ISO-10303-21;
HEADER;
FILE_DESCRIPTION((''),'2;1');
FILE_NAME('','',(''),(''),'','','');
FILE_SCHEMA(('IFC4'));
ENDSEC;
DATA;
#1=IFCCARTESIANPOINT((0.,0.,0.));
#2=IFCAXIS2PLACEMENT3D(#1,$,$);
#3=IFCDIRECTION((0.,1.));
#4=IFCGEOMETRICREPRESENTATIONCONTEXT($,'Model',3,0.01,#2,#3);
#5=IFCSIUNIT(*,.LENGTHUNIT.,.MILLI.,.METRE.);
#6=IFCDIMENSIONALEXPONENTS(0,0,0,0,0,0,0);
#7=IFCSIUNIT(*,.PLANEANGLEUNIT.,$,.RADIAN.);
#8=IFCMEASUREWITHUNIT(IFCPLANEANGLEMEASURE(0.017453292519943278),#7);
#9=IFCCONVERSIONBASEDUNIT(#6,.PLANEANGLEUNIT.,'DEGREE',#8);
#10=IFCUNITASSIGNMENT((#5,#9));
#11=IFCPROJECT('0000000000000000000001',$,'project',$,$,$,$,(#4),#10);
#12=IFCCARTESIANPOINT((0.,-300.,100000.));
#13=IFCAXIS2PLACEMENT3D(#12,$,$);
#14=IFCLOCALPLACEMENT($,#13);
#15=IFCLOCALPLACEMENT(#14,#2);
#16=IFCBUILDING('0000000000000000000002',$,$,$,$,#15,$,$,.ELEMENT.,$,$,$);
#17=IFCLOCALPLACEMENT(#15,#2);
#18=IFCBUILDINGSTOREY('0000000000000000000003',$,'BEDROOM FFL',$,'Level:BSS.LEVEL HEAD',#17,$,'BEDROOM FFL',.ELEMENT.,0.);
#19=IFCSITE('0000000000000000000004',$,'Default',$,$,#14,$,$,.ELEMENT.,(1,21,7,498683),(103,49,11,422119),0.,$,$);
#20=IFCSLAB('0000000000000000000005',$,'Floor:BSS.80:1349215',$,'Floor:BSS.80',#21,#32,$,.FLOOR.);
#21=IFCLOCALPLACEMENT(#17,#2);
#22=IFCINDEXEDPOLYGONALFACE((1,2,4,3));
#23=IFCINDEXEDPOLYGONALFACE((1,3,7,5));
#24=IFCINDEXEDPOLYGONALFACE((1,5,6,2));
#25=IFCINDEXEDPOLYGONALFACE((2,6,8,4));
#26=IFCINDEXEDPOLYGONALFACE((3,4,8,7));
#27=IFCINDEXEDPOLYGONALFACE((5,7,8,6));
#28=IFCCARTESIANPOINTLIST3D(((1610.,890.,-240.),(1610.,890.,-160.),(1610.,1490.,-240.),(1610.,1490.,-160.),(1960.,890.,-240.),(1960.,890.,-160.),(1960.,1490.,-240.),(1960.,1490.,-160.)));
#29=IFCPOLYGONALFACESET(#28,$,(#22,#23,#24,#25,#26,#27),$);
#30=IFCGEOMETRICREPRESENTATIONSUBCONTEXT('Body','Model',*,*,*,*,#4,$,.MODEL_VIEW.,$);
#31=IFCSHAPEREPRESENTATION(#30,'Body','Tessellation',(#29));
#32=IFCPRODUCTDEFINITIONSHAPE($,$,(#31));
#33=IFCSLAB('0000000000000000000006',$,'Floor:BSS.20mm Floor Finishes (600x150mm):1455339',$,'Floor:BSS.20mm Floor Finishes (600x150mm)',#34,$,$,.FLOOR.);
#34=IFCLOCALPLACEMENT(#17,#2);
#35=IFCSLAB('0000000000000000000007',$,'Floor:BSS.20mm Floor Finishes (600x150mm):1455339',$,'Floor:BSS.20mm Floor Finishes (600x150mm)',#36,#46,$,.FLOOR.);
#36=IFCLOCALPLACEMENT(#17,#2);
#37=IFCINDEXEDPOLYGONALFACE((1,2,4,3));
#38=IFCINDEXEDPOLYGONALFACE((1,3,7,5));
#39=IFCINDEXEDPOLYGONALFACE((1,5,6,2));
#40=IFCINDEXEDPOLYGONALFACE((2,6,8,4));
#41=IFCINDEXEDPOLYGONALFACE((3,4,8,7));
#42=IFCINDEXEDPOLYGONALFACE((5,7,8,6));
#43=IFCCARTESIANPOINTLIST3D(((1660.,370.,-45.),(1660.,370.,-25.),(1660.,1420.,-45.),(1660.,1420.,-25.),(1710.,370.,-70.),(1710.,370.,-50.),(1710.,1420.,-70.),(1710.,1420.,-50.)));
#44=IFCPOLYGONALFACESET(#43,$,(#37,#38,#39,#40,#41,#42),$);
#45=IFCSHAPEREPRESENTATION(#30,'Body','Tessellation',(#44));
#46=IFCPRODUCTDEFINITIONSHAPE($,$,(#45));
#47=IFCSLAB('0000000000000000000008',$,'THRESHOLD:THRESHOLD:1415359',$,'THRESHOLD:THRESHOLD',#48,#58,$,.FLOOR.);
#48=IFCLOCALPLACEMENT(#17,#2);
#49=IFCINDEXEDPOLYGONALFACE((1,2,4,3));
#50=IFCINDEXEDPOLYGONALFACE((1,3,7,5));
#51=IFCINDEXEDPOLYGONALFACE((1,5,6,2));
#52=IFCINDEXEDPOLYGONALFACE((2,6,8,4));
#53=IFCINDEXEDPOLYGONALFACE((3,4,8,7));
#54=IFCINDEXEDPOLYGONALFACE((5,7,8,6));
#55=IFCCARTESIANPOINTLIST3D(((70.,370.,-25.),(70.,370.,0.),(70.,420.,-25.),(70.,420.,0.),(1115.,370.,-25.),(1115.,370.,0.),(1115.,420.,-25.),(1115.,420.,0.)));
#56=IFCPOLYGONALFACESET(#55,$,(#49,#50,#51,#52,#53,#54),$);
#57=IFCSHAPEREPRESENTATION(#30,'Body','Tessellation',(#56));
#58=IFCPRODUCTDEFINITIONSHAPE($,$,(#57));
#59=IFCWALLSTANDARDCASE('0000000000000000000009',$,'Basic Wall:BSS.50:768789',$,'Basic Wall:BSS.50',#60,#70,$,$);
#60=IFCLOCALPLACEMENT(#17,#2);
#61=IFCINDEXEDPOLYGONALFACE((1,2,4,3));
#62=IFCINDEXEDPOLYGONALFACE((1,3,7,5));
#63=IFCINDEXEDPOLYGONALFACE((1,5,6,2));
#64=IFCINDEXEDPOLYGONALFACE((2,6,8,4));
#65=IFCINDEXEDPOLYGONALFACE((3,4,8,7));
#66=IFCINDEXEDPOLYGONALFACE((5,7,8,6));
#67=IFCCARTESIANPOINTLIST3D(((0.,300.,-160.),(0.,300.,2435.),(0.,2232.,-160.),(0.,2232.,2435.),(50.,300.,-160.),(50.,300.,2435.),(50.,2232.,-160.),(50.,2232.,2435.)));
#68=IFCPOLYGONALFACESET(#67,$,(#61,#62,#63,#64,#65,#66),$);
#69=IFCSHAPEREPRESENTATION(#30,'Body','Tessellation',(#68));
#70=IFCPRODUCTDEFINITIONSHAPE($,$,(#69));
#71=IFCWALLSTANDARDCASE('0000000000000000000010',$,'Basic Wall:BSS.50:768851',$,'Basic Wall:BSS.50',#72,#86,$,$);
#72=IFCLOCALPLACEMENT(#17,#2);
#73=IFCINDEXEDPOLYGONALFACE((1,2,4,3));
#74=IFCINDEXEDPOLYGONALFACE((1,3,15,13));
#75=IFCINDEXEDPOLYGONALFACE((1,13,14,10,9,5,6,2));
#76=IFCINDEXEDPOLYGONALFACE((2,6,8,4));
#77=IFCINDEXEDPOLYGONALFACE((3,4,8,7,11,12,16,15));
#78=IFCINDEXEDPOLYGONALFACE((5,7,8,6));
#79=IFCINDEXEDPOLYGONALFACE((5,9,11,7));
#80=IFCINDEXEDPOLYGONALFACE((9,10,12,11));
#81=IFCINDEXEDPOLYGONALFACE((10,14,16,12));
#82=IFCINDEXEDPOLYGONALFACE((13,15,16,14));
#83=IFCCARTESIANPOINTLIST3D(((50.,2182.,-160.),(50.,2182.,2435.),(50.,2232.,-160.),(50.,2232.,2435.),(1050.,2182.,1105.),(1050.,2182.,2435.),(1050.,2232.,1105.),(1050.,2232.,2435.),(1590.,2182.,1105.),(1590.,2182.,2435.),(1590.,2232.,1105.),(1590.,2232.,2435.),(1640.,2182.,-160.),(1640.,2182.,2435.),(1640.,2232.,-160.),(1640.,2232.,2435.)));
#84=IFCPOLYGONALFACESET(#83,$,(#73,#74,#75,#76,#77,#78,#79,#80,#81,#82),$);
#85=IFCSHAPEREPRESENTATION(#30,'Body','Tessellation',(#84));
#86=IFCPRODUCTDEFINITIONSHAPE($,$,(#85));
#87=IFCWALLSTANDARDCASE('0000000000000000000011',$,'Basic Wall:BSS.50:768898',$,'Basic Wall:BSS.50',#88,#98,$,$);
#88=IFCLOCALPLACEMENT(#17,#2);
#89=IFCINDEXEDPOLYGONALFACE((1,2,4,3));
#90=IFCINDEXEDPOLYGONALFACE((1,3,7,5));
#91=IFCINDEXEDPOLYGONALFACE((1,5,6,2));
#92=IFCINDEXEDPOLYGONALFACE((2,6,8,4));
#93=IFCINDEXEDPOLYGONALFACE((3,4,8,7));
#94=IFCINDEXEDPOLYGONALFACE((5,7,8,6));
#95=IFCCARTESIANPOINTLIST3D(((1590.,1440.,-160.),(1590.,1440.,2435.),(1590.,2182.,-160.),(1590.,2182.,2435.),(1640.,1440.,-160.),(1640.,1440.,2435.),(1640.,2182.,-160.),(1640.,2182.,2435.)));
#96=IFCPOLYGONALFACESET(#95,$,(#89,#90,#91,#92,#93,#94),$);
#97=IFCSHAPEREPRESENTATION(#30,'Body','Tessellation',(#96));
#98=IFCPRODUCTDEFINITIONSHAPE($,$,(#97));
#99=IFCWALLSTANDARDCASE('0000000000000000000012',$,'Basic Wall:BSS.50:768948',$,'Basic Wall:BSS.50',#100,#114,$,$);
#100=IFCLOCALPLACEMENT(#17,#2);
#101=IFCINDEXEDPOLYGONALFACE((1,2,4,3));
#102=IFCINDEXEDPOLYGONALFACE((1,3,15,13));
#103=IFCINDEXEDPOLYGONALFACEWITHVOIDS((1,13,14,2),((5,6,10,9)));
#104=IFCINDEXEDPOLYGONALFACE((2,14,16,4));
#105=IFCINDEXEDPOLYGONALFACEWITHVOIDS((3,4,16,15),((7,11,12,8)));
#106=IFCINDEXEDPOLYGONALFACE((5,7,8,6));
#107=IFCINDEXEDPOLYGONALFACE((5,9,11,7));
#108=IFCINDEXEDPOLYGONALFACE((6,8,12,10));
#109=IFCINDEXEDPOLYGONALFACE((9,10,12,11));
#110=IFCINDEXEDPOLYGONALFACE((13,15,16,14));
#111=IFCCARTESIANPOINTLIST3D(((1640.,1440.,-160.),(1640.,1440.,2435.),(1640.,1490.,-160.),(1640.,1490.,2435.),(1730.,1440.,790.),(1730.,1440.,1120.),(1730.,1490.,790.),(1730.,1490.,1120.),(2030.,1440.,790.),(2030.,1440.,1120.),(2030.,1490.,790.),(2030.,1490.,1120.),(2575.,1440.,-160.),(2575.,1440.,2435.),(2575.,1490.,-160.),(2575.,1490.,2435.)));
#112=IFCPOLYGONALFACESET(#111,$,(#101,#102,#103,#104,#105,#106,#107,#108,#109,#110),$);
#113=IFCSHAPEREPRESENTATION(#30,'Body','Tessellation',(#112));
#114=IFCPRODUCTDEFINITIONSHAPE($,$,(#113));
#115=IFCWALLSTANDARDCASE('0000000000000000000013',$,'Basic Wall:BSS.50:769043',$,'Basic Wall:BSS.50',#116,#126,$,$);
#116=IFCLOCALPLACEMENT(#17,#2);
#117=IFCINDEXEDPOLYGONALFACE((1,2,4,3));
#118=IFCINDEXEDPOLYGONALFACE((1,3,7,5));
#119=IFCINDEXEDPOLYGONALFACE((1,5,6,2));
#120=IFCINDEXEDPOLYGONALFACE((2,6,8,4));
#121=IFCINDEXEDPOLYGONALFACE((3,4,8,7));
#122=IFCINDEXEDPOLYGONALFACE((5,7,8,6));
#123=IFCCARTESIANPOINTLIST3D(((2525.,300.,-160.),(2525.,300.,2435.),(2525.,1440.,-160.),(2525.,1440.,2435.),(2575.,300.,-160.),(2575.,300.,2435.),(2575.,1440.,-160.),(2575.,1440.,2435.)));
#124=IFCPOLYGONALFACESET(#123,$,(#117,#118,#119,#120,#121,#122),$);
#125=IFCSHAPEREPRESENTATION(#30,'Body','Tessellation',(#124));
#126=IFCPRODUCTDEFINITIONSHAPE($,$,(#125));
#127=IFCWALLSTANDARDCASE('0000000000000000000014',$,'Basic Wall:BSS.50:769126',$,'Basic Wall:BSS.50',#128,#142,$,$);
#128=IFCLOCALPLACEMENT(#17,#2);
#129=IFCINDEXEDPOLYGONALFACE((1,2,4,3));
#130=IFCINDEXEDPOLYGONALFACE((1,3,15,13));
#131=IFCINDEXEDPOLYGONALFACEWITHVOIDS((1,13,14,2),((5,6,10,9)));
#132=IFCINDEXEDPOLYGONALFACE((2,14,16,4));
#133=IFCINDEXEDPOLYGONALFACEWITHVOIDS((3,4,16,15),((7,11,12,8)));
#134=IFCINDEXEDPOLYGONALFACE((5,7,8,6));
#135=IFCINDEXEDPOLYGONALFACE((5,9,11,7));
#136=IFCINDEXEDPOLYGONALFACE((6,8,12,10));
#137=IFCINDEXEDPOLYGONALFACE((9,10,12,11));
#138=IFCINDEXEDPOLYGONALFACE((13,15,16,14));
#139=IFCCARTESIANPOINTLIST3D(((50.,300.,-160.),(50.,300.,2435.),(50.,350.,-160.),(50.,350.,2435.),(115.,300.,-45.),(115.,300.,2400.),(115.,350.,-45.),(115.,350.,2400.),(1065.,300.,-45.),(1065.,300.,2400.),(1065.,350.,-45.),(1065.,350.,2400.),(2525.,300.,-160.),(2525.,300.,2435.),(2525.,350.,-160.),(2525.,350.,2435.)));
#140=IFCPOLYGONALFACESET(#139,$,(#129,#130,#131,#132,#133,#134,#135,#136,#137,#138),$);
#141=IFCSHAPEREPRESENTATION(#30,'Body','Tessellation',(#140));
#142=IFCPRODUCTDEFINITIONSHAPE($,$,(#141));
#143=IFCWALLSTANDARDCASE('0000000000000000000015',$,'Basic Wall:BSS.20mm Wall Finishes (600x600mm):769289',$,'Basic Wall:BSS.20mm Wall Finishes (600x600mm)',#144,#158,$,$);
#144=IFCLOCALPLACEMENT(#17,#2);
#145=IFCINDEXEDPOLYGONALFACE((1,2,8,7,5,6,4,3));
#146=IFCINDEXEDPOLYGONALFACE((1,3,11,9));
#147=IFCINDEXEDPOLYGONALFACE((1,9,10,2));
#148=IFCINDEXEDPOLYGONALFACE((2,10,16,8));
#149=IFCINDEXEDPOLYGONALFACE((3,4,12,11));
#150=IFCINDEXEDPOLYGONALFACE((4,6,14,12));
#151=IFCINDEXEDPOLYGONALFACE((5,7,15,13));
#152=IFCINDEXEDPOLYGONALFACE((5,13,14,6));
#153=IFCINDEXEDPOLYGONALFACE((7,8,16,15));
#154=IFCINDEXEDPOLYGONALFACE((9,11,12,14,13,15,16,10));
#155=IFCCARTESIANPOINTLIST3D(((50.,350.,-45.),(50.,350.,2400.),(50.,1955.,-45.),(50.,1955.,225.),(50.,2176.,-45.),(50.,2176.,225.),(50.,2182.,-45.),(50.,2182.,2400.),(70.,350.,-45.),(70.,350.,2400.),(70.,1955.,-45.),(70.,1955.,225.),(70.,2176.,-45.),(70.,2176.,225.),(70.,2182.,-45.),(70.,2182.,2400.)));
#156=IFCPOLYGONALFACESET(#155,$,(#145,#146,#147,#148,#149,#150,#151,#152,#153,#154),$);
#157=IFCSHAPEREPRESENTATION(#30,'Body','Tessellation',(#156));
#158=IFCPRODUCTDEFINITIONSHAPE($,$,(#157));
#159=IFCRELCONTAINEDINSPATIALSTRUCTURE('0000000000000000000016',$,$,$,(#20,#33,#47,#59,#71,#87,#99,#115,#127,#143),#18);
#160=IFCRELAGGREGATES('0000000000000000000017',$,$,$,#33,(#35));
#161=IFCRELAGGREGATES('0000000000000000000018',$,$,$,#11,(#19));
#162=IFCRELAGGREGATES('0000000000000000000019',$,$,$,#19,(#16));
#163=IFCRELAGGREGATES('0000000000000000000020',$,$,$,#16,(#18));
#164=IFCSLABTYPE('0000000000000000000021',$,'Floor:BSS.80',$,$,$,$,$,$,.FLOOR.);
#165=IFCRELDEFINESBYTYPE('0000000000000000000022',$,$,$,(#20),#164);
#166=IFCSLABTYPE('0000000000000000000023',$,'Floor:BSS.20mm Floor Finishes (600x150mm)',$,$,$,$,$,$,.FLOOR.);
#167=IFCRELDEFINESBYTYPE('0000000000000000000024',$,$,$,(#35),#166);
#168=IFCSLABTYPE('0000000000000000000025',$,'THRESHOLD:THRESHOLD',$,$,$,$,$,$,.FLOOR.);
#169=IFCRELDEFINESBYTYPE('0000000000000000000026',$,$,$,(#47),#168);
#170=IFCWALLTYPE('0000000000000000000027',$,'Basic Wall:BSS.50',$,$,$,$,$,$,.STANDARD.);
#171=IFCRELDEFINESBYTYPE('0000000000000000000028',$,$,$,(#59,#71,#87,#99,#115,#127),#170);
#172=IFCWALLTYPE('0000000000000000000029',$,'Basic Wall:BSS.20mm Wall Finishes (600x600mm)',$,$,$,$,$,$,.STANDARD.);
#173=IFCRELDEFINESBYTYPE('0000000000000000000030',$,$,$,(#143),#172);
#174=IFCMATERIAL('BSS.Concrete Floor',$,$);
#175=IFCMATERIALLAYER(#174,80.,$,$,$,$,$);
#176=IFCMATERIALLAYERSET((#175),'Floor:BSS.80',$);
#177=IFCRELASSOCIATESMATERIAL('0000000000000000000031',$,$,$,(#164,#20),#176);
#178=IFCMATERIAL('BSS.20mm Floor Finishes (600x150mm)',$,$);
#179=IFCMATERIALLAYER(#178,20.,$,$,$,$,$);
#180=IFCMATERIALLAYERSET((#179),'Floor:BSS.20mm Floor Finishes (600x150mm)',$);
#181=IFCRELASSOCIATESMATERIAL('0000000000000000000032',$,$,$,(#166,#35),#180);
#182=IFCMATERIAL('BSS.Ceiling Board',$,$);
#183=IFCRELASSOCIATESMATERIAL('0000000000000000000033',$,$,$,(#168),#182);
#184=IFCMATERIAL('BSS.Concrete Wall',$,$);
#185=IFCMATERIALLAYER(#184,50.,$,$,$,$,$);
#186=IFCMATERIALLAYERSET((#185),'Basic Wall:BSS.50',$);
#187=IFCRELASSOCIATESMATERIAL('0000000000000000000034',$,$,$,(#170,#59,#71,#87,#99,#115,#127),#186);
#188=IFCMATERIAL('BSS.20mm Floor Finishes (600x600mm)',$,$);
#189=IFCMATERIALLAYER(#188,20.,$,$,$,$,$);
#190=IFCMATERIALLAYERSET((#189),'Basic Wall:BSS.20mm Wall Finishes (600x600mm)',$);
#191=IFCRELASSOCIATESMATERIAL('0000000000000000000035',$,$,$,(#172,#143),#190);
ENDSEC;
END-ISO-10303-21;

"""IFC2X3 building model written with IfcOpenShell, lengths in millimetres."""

from ifc_helpers import new_model, entity, si_unit, converted_unit, direction, frame, frame_2d, origin, origin_2d_with_axis, place, context, subcontext, project, spatial, rectangle, extrude, material, layer, layer_set, layer_usage, type_object, element, aggregate, save


model = new_model("IFC2X3")

# Units and contexts
model_context = context("Model", 3, precision=0.01, world=origin(), true_north=direction((0.0, 1.0)))
body_context = subcontext(model_context, "Body", "Model", "MODEL_VIEW")
ifc_project = project(units=[si_unit("LENGTHUNIT", "METRE", prefix="MILLI"), converted_unit("PLANEANGLEUNIT", "DEGREE", entity("IfcPlaneAngleMeasure", 0.017453292519943278), si_unit("PLANEANGLEUNIT", "RADIAN"), dimensions=[0, 0, 0, 0, 0, 0, 0])], contexts=[model_context])

# Site, building, storey
site_placement = place(None, frame((0.0, -300.0, 100000.0)))
site = spatial("IfcSite", under=ifc_project, at=site_placement, Name="Default", CompositionType="ELEMENT", RefLatitude=(1, 21, 7, 498683), RefLongitude=(103, 49, 11, 422119), RefElevation=0.0)
building_placement = place(site_placement, origin())
building = spatial("IfcBuilding", under=site, at=building_placement, CompositionType="ELEMENT")
storey_placement = place(building_placement, origin())
storey = spatial("IfcBuildingStorey", under=building, at=storey_placement, Name="BEDROOM FFL", ObjectType="Level:BSS.LEVEL HEAD", LongName="BEDROOM FFL", CompositionType="ELEMENT", Elevation=0.0)

# Slabs
ifc_material_1 = material(Name="BSS.Concrete Floor")
ifc_material_2 = material(Name="BSS.20mm Floor Finishes (600x600mm)")
ifc_layer_1 = layer(ifc_material_1, 80.0)
ifc_layer_set_1 = layer_set([ifc_layer_1], Name="Floor:BSS.80")
ifc_layer_usage_1 = layer_usage(ifc_layer_set_1, "AXIS3", "POSITIVE", 0.0)
slab_type_1 = type_object("IfcSlabType", Name="Floor:BSS.80", PredefinedType="FLOOR", material=ifc_layer_set_1)
slab_1_placement = place(storey_placement, origin())
element("IfcSlab", 1, at=slab_1_placement, inside=storey, type_object=slab_type_1, material=ifc_layer_usage_1, Name="Floor:BSS.80:1349215", ObjectType="Floor:BSS.80", PredefinedType="FLOOR", context=body_context, shape_type="SweptSolid", body=[
    extrude(rectangle(XDim=600.0, YDim=350.0, at=frame_2d((0.0, 0.0), x_axis=(1.0, 0.0))), frame((1785.0, 1190.0, -160.0), z_axis=(0.0, 0.0, -1.0), x_axis=(0.0, 1.0, 0.0)), (0.0, 0.0, 1.0), 80.0),
])
ifc_material_3 = material(Name="BSS.20mm Floor Finishes (600x150mm)")
ifc_layer_2 = layer(ifc_material_3, 20.0)
ifc_layer_set_2 = layer_set([ifc_layer_2], Name="Floor:BSS.20mm Floor Finishes (600x150mm)")
slab_type_2 = type_object("IfcSlabType", Name="Floor:BSS.20mm Floor Finishes (600x150mm)", PredefinedType="FLOOR", material=ifc_layer_set_2)
slab_2_placement = place(storey_placement, frame((1640.0, 370.0, -70.0)))
slab_2 = element("IfcSlab", 2, at=slab_2_placement, inside=storey, Name="Floor:BSS.20mm Floor Finishes (600x150mm):1455339", ObjectType="Floor:BSS.20mm Floor Finishes (600x150mm)", PredefinedType="FLOOR")
slab_3_placement = place(slab_2_placement, origin())
slab_3 = element("IfcSlab", 3, at=slab_3_placement, type_object=slab_type_2, material=ifc_layer_set_2, Name="Floor:BSS.20mm Floor Finishes (600x150mm):1455339", ObjectType="Floor:BSS.20mm Floor Finishes (600x150mm)", PredefinedType="FLOOR", context=body_context, shape_type="SweptSolid", body=[
    extrude(rectangle(XDim=1050.0, YDim=55.9, at=frame_2d((0.0, 0.0), x_axis=(0.0, 1.0))), frame((45.0, 525.0, 32.5), z_axis=(0.44722, 0.0, 0.894424), x_axis=(0.894424, 0.0, -0.44722)), (0.44722, 0.0, -0.894424), 20.0),
])
aggregate(slab_2, [slab_3])

# Slab
ifc_material_4 = material(Name="BSS.Ceiling Board")
slab_type_3 = type_object("IfcSlabType", Name="THRESHOLD:THRESHOLD", PredefinedType="FLOOR", material=ifc_material_4)
slab_4_placement = place(storey_placement, origin())
element("IfcSlab", 4, at=slab_4_placement, inside=storey, type_object=slab_type_3, Name="THRESHOLD:THRESHOLD:1415359", ObjectType="THRESHOLD:THRESHOLD", PredefinedType="FLOOR", context=body_context, shape_type="SweptSolid", body=[
    extrude(rectangle(XDim=1045.0, YDim=50.0, at=frame_2d((0.0, 0.0), x_axis=(1.0, 0.0))), frame((592.5, 395.0, -25.0)), (0.0, 0.0, 1.0), 25.0),
])

# Wall
ifc_material_5 = material(Name="BSS.Concrete Wall")
ifc_layer_3 = layer(ifc_material_5, 50.0)
ifc_layer_set_3 = layer_set([ifc_layer_3], Name="Basic Wall:BSS.50")
ifc_layer_usage_2 = layer_usage(ifc_layer_set_3, "AXIS2", "NEGATIVE", 25.0)
wall_type_1 = type_object("IfcWallType", Name="Basic Wall:BSS.50", PredefinedType="STANDARD", material=ifc_layer_set_3)
wall_1_placement = place(storey_placement, frame((25.0, 300.0, -160.0), z_axis=(0.0, 0.0, 1.0), x_axis=(0.0, 1.0, 0.0)))
element("IfcWallStandardCase", 5, at=wall_1_placement, inside=storey, type_object=wall_type_1, material=ifc_layer_usage_2, Name="Basic Wall:BSS.50:768789", ObjectType="Basic Wall:BSS.50", context=body_context, shape_type="SweptSolid", body=[
    extrude(rectangle(XDim=1932.0, YDim=50.0, at=frame_2d((966.0, 0.0), x_axis=(-1.0, 0.0))), origin(), (0.0, 0.0, 1.0), 2595.0),
])

# Wall, opening
ifc_layer_usage_3 = layer_usage(ifc_layer_set_3, "AXIS2", "POSITIVE", -25.0)
wall_2_placement = place(storey_placement, frame((50.0, 2207.0, -160.0)))
wall_2 = element("IfcWallStandardCase", 6, at=wall_2_placement, inside=storey, type_object=wall_type_1, material=ifc_layer_usage_3, Name="Basic Wall:BSS.50:768851", ObjectType="Basic Wall:BSS.50", context=body_context, shape_type="SweptSolid", body=[
    extrude(rectangle(XDim=1590.0, YDim=50.0, at=frame_2d((795.0, 0.0), x_axis=(-1.0, 0.0))), origin(), (0.0, 0.0, 1.0), 2595.0),
])
opening_1_placement = place(wall_2_placement, frame((-50.0, -2207.0, 160.0)))
element("IfcOpeningElement", 7, at=opening_1_placement, cuts=wall_2, ObjectType="Opening", context=body_context, shape_type="SweptSolid", body=[
    extrude(rectangle(XDim=1330.0, YDim=540.0, at=frame_2d((0.0, 0.0), x_axis=(0.0, 1.0))), frame((1320.0, 658.0, 1770.0), z_axis=(0.0, 1.0, 0.0), x_axis=(1.0, 0.0, 0.0)), (0.0, 0.0, 1.0), 3048.0),
])

# Wall
ifc_layer_usage_4 = layer_usage(ifc_layer_set_3, "AXIS2", "POSITIVE", -25.0)
wall_3_placement = place(storey_placement, frame((1615.0, 2182.0, -160.0), z_axis=(0.0, 0.0, 1.0), x_axis=(0.0, -1.0, 0.0)))
element("IfcWallStandardCase", 8, at=wall_3_placement, inside=storey, type_object=wall_type_1, material=ifc_layer_usage_4, Name="Basic Wall:BSS.50:768898", ObjectType="Basic Wall:BSS.50", context=body_context, shape_type="SweptSolid", body=[
    extrude(rectangle(XDim=742.0, YDim=50.0, at=frame_2d((371.0, 0.0), x_axis=(-1.0, 0.0))), origin(), (0.0, 0.0, 1.0), 2595.0),
])

# Wall, opening
ifc_layer_usage_5 = layer_usage(ifc_layer_set_3, "AXIS2", "POSITIVE", -25.0)
wall_4_placement = place(storey_placement, frame((1640.0, 1465.0, -160.0)))
wall_4 = element("IfcWallStandardCase", 9, at=wall_4_placement, inside=storey, type_object=wall_type_1, material=ifc_layer_usage_5, Name="Basic Wall:BSS.50:768948", ObjectType="Basic Wall:BSS.50", context=body_context, shape_type="SweptSolid", body=[
    extrude(rectangle(XDim=935.0, YDim=50.0, at=frame_2d((467.5, 0.0), x_axis=(-1.0, 0.0))), origin(), (0.0, 0.0, 1.0), 2595.0),
])
opening_2_placement = place(wall_4_placement, origin())
element("IfcOpeningElement", 10, at=opening_2_placement, cuts=wall_4, ObjectType="Opening", context=body_context, shape_type="SweptSolid", body=[
    extrude(rectangle(XDim=330.0, YDim=300.0, at=frame_2d((0.0, 0.0), x_axis=(0.0, 1.0))), frame((240.0, 25.0, 1115.0), z_axis=(0.0, -1.0, 0.0), x_axis=(-1.0, 0.0, 0.0)), (0.0, 0.0, 1.0), 50.0),
])

# Wall
ifc_layer_usage_6 = layer_usage(ifc_layer_set_3, "AXIS2", "POSITIVE", -25.0)
wall_5_placement = place(storey_placement, frame((2550.0, 1440.0, -160.0), z_axis=(0.0, 0.0, 1.0), x_axis=(0.0, -1.0, 0.0)))
element("IfcWallStandardCase", 11, at=wall_5_placement, inside=storey, type_object=wall_type_1, material=ifc_layer_usage_6, Name="Basic Wall:BSS.50:769043", ObjectType="Basic Wall:BSS.50", context=body_context, shape_type="SweptSolid", body=[
    extrude(rectangle(XDim=1140.0, YDim=50.0, at=frame_2d((570.0, 0.0), x_axis=(-1.0, 0.0))), origin(), (0.0, 0.0, 1.0), 2595.0),
])

# Walls, openings
ifc_layer_usage_7 = layer_usage(ifc_layer_set_3, "AXIS2", "NEGATIVE", 25.0)
wall_6_placement = place(storey_placement, frame((2525.0, 325.0, -160.0), z_axis=(0.0, 0.0, 1.0), x_axis=(-1.0, 0.0, 0.0)))
wall_6 = element("IfcWallStandardCase", 12, at=wall_6_placement, inside=storey, type_object=wall_type_1, material=ifc_layer_usage_7, Name="Basic Wall:BSS.50:769126", ObjectType="Basic Wall:BSS.50", context=body_context, shape_type="SweptSolid", body=[
    extrude(rectangle(XDim=2475.0, YDim=50.0, at=frame_2d((1237.5, 0.0), x_axis=(-1.0, 0.0))), origin(), (0.0, 0.0, 1.0), 2595.0),
])
opening_3_placement = place(wall_6_placement, frame((2525.0, 325.0, 160.0), z_axis=(0.0, 0.0, 1.0), x_axis=(-1.0, 0.0, 0.0)))
element("IfcOpeningElement", 13, at=opening_3_placement, cuts=wall_6, ObjectType="Opening", context=body_context, shape_type="SweptSolid", body=[
    extrude(rectangle(XDim=2445.0, YDim=950.0, at=origin_2d_with_axis()), frame((590.0, 1874.0, 1177.5), z_axis=(0.0, -1.0, 0.0), x_axis=(0.0, 0.0, -1.0)), (0.0, 0.0, 1.0), 3048.0),
])
ifc_layer_4 = layer(ifc_material_2, 20.0)
ifc_layer_set_4 = layer_set([ifc_layer_4], Name="Basic Wall:BSS.20mm Wall Finishes (600x600mm)")
ifc_layer_usage_8 = layer_usage(ifc_layer_set_4, "AXIS2", "NEGATIVE", 10.0)
wall_type_2 = type_object("IfcWallType", Name="Basic Wall:BSS.20mm Wall Finishes (600x600mm)", PredefinedType="STANDARD", material=ifc_layer_set_4)
wall_7_placement = place(storey_placement, frame((60.0, 350.0, -45.0), z_axis=(0.0, 0.0, 1.0), x_axis=(0.0, 1.0, 0.0)))
wall_7 = element("IfcWallStandardCase", 14, at=wall_7_placement, inside=storey, type_object=wall_type_2, material=ifc_layer_usage_8, Name="Basic Wall:BSS.20mm Wall Finishes (600x600mm):769289", ObjectType="Basic Wall:BSS.20mm Wall Finishes (600x600mm)", context=body_context, shape_type="SweptSolid", body=[
    extrude(rectangle(XDim=1832.0, YDim=20.0, at=frame_2d((916.0, 0.0), x_axis=(-1.0, 0.0))), origin(), (0.0, 0.0, 1.0), 2445.0),
])
opening_4_placement = place(wall_7_placement, origin())
element("IfcOpeningElement", 15, at=opening_4_placement, cuts=wall_7, ObjectType="Opening", context=body_context, shape_type="SweptSolid", body=[
    extrude(rectangle(XDim=270.0, YDim=221.0, at=frame_2d((0.0, 0.0), x_axis=(0.0, 1.0))), frame((1715.5, 10.0, 135.0), z_axis=(0.0, -1.0, 0.0), x_axis=(1.0, 0.0, 0.0)), (0.0, 0.0, 1.0), 20.0),
])

save(model, "model.ifc")
